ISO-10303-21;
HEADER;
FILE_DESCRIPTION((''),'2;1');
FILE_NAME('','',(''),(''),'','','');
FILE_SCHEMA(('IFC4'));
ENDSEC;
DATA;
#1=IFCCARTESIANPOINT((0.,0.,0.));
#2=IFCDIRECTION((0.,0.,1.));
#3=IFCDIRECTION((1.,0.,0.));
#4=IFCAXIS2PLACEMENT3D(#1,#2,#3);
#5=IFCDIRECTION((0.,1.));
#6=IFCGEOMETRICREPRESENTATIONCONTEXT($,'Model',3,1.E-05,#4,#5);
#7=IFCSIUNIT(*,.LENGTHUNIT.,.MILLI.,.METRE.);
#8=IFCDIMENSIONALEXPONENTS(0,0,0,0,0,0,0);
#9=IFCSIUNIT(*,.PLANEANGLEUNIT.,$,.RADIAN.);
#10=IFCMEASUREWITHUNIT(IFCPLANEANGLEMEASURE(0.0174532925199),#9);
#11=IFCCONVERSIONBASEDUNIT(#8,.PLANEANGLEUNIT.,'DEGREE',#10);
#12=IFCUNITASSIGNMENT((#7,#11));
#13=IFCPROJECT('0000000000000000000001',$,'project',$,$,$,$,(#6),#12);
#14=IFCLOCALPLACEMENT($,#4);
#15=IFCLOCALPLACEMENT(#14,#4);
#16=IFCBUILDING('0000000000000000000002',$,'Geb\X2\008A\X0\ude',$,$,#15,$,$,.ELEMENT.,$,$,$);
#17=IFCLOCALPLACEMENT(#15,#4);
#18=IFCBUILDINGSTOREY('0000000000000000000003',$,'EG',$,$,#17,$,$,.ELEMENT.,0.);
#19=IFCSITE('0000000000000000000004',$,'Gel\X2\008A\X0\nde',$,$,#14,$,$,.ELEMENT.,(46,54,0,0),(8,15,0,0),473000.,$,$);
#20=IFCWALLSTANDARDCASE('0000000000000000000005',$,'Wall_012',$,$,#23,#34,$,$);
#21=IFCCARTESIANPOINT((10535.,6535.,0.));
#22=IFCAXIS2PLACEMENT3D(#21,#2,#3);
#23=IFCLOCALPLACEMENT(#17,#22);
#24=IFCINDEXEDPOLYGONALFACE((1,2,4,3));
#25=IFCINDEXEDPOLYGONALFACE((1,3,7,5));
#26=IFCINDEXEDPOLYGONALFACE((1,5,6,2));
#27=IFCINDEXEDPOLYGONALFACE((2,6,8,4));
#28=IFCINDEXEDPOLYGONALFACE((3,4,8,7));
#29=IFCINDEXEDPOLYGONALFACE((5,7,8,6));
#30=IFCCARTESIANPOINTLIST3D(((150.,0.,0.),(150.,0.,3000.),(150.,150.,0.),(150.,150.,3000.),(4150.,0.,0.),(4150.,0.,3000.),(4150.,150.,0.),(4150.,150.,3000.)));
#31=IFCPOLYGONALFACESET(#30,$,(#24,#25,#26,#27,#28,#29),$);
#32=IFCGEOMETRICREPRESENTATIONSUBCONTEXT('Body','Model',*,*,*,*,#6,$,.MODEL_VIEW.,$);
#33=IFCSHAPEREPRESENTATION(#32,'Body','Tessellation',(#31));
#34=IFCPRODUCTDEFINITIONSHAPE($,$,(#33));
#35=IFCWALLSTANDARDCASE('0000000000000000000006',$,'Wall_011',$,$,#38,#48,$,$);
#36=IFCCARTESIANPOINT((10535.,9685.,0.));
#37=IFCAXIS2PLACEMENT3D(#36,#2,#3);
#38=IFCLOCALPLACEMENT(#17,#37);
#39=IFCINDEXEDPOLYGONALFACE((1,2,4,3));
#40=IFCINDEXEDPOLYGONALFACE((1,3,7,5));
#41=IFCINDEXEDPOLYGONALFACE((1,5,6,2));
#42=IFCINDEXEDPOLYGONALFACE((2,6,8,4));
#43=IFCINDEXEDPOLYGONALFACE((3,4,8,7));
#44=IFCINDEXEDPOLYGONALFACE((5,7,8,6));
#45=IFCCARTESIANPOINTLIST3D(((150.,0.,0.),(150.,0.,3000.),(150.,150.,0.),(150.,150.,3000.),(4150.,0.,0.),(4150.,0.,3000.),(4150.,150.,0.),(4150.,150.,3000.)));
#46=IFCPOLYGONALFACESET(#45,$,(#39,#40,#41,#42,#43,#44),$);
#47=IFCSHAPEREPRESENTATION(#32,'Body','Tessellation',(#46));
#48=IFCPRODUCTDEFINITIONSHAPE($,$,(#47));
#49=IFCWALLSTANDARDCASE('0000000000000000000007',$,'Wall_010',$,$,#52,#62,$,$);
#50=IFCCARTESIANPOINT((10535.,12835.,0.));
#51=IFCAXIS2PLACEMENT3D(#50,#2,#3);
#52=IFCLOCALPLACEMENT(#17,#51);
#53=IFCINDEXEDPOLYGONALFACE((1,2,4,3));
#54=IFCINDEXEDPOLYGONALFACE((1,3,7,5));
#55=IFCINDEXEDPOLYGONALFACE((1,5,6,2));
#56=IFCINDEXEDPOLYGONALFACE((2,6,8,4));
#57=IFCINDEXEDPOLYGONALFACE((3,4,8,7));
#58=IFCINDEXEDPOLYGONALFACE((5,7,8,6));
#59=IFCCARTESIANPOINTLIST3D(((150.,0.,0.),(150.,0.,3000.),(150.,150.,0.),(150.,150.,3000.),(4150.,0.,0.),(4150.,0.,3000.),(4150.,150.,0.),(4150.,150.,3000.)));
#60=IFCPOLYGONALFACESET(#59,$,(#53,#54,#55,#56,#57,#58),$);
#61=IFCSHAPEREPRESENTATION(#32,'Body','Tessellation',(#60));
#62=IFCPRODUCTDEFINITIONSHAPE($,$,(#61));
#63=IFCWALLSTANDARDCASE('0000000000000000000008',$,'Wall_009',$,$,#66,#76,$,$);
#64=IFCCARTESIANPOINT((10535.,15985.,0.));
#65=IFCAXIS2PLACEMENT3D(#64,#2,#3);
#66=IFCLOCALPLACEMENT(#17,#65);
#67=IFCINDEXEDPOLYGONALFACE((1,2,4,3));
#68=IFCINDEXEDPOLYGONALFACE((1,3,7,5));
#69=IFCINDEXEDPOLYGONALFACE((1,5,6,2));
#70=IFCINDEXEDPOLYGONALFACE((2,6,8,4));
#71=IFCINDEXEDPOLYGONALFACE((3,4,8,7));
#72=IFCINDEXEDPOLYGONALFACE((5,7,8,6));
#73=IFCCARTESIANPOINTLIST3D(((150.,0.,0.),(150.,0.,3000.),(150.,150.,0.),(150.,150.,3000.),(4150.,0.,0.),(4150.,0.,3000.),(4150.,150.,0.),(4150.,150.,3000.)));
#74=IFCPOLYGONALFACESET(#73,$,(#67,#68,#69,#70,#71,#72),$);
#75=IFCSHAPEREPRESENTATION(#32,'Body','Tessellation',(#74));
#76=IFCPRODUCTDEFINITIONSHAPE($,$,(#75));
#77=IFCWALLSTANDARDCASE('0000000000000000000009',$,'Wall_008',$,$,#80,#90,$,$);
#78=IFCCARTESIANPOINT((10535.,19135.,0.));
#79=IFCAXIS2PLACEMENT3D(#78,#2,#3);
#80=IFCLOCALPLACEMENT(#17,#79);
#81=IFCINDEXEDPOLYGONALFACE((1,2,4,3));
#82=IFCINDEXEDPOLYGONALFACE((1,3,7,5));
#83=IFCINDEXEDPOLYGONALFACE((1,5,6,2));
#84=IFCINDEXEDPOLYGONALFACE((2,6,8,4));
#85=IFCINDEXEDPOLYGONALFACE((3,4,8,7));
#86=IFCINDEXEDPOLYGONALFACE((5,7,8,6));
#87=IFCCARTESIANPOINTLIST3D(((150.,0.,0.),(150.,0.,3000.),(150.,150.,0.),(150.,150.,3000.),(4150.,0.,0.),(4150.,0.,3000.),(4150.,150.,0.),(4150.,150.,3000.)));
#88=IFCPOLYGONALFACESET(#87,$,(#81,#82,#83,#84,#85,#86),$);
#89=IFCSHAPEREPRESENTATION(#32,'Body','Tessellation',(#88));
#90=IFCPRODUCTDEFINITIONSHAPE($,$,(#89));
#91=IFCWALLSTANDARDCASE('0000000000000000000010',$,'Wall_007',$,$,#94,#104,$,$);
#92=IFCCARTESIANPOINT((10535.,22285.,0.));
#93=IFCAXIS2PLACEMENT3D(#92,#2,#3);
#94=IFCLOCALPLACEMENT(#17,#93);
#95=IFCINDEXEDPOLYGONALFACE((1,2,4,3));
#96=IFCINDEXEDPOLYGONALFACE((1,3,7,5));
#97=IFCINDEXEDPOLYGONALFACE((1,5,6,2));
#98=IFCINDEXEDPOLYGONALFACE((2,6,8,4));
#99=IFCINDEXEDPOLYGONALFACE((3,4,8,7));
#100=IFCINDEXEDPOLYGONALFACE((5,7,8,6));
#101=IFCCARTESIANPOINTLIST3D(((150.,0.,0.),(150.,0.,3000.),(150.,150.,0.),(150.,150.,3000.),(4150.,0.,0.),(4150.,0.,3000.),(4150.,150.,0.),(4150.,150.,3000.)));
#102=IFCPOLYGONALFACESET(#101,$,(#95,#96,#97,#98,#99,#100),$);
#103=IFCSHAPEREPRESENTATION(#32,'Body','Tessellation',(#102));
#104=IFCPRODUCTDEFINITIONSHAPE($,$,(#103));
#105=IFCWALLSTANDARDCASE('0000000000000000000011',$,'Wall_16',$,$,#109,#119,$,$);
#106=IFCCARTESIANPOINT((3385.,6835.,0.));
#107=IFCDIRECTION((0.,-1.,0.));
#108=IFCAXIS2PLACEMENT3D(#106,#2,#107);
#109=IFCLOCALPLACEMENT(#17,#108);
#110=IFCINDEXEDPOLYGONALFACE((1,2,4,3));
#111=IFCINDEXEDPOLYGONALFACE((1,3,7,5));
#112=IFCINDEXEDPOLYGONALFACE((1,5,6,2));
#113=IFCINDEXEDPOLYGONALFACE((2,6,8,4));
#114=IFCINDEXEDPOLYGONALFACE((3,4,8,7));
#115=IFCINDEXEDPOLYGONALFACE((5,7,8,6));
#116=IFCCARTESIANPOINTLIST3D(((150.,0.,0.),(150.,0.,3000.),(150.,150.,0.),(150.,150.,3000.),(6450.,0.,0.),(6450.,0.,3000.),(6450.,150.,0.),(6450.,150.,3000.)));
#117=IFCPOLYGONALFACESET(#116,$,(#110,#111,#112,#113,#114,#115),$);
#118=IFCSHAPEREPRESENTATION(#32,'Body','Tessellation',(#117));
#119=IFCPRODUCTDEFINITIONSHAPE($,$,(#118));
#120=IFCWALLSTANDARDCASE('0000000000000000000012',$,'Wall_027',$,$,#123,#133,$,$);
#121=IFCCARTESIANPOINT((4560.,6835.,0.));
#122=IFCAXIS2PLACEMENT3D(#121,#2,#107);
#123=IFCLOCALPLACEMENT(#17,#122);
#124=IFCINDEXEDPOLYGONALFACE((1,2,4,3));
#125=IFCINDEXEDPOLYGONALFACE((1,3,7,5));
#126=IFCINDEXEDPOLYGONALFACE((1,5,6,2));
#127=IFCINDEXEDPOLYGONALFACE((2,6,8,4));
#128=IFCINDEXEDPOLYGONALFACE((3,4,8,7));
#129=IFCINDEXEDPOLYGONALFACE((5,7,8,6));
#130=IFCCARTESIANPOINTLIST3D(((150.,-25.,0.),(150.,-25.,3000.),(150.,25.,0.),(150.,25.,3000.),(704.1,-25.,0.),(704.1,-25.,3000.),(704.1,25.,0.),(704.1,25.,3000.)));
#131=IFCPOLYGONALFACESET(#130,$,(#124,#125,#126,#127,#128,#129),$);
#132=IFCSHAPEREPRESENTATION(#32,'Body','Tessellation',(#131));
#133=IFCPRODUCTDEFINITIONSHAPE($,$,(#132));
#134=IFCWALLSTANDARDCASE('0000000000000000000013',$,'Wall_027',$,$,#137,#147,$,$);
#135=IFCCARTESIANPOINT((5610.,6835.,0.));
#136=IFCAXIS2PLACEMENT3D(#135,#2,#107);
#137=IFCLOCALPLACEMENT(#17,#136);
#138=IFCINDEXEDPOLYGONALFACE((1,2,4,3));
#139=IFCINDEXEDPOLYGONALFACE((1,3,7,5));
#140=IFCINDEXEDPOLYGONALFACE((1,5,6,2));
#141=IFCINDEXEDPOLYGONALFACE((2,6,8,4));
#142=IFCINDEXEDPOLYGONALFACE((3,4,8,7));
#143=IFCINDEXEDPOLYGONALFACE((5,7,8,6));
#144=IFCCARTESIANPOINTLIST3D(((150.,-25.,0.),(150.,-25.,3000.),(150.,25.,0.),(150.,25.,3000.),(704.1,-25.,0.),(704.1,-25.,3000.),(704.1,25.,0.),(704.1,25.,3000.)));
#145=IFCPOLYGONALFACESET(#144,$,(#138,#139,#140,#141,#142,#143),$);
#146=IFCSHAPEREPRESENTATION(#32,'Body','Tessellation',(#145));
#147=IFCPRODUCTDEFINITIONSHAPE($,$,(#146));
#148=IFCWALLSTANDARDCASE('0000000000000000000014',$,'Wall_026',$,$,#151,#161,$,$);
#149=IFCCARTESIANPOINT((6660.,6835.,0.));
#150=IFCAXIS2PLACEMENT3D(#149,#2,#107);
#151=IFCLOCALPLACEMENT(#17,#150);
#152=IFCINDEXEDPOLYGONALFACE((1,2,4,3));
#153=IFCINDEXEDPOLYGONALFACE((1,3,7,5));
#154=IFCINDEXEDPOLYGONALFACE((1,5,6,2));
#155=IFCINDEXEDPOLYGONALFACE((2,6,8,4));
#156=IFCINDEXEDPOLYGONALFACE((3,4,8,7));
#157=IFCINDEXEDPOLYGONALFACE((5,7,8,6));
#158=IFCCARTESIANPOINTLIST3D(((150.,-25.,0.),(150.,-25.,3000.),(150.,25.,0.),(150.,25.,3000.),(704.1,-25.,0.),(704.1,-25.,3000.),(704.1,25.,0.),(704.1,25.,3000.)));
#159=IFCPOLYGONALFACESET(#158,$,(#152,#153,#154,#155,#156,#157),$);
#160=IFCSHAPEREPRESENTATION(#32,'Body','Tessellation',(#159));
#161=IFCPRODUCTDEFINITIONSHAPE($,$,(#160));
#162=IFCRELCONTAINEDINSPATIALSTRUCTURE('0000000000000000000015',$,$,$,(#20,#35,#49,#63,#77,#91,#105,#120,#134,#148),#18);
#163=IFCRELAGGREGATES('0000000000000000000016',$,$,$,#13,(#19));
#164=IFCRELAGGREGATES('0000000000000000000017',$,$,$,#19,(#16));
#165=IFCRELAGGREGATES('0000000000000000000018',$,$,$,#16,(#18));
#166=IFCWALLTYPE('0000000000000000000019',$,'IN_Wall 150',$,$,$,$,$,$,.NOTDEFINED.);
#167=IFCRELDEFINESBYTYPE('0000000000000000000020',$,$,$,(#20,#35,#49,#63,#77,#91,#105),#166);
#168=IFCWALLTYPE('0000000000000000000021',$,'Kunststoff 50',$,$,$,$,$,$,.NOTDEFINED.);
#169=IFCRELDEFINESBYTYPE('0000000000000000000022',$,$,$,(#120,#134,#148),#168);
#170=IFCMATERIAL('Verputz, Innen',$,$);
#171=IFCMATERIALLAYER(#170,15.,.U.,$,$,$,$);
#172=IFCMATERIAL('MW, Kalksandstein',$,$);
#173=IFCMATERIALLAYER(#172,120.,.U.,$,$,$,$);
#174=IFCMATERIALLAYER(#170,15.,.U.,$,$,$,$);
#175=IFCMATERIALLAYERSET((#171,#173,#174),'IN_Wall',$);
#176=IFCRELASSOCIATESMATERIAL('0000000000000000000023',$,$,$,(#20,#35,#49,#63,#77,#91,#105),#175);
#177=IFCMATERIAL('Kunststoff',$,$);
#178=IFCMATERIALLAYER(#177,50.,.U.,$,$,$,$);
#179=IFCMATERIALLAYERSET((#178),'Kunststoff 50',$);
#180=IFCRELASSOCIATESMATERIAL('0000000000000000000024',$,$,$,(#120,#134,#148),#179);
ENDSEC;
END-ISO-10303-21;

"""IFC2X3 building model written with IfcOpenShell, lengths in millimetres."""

from ifc_helpers import new_model, entity, si_unit, converted_unit, direction, frame, origin_with_axes, place, context, subcontext, project, spatial, polyline, outline, extrude, material, layer, layer_set, layer_usage, type_object, element, save


model = new_model("IFC2X3")

# Units and contexts
model_context = context("Model", 3, precision=1e-05, world=origin_with_axes(), true_north=direction((0.0, 1.0)))
body_context = subcontext(model_context, "Body", "Model", "MODEL_VIEW")
ifc_project = project(units=[si_unit("LENGTHUNIT", "METRE", prefix="MILLI"), converted_unit("PLANEANGLEUNIT", "DEGREE", entity("IfcPlaneAngleMeasure", 0.0174532925199), si_unit("PLANEANGLEUNIT", "RADIAN"), dimensions=[0, 0, 0, 0, 0, 0, 0])], contexts=[model_context])

# Site, building, storey
site_placement = place(None, origin_with_axes())
site = spatial("IfcSite", under=ifc_project, at=site_placement, Name="Gel\u008ande", CompositionType="ELEMENT", RefLatitude=(46, 54, 0, 0), RefLongitude=(8, 15, 0, 0), RefElevation=473000.0)
building_placement = place(site_placement, origin_with_axes())
building = spatial("IfcBuilding", under=site, at=building_placement, Name="Geb\u008aude", CompositionType="ELEMENT")
storey_placement = place(building_placement, origin_with_axes())
storey = spatial("IfcBuildingStorey", under=building, at=storey_placement, Name="EG", CompositionType="ELEMENT", Elevation=0.0)

# Shared definitions
ifc_material_1 = material(Name="Verputz, Innen")
ifc_layer_1 = layer(ifc_material_1, 15.0, ventilated="UNKNOWN")
ifc_material_2 = material(Name="MW, Kalksandstein")
ifc_layer_2 = layer(ifc_material_2, 120.0, ventilated="UNKNOWN")
ifc_layer_3 = layer(ifc_material_1, 15.0, ventilated="UNKNOWN")
ifc_layer_set_1 = layer_set([ifc_layer_1, ifc_layer_2, ifc_layer_3], Name="IN_Wall")
wall_type_1 = type_object("IfcWallType", Name="IN_Wall 150", PredefinedType="NOTDEFINED")

# Walls
ifc_layer_usage_1 = layer_usage(ifc_layer_set_1, "AXIS2", "POSITIVE", 0.0)
wall_1_placement = place(storey_placement, frame((10535.0, 6535.0, 0.0), z_axis=(0.0, 0.0, 1.0), x_axis=(1.0, 0.0, 0.0)))
element("IfcWallStandardCase", 1, at=wall_1_placement, inside=storey, type_object=wall_type_1, material=ifc_layer_usage_1, Name="Wall_012", context=body_context, shape_type="SweptSolid", body=[
    extrude(outline(polyline([(150.0, 0.0), (4150.0, 0.0), (4150.0, 150.0), (150.0, 150.0), (150.0, 0.0)])), origin_with_axes(), (0.0, 0.0, 1.0), 3000.0),
])
ifc_layer_usage_2 = layer_usage(ifc_layer_set_1, "AXIS2", "POSITIVE", 0.0)
wall_2_placement = place(storey_placement, frame((10535.0, 9685.0, 0.0), z_axis=(0.0, 0.0, 1.0), x_axis=(1.0, 0.0, 0.0)))
element("IfcWallStandardCase", 2, at=wall_2_placement, inside=storey, type_object=wall_type_1, material=ifc_layer_usage_2, Name="Wall_011", context=body_context, shape_type="SweptSolid", body=[
    extrude(outline(polyline([(150.0, 0.0), (4150.0, 0.0), (4150.0, 150.0), (150.0, 150.0), (150.0, 0.0)])), origin_with_axes(), (0.0, 0.0, 1.0), 3000.0),
])
ifc_layer_usage_3 = layer_usage(ifc_layer_set_1, "AXIS2", "POSITIVE", 0.0)
wall_3_placement = place(storey_placement, frame((10535.0, 12835.0, 0.0), z_axis=(0.0, 0.0, 1.0), x_axis=(1.0, 0.0, 0.0)))
element("IfcWallStandardCase", 3, at=wall_3_placement, inside=storey, type_object=wall_type_1, material=ifc_layer_usage_3, Name="Wall_010", context=body_context, shape_type="SweptSolid", body=[
    extrude(outline(polyline([(150.0, 0.0), (4150.0, 0.0), (4150.0, 150.0), (150.0, 150.0), (150.0, 0.0)])), origin_with_axes(), (0.0, 0.0, 1.0), 3000.0),
])
ifc_layer_usage_4 = layer_usage(ifc_layer_set_1, "AXIS2", "POSITIVE", 0.0)
wall_4_placement = place(storey_placement, frame((10535.0, 15985.0, 0.0), z_axis=(0.0, 0.0, 1.0), x_axis=(1.0, 0.0, 0.0)))
element("IfcWallStandardCase", 4, at=wall_4_placement, inside=storey, type_object=wall_type_1, material=ifc_layer_usage_4, Name="Wall_009", context=body_context, shape_type="SweptSolid", body=[
    extrude(outline(polyline([(150.0, 0.0), (4150.0, 0.0), (4150.0, 150.0), (150.0, 150.0), (150.0, 0.0)])), origin_with_axes(), (0.0, 0.0, 1.0), 3000.0),
])
ifc_layer_usage_5 = layer_usage(ifc_layer_set_1, "AXIS2", "POSITIVE", 0.0)
wall_5_placement = place(storey_placement, frame((10535.0, 19135.0, 0.0), z_axis=(0.0, 0.0, 1.0), x_axis=(1.0, 0.0, 0.0)))
element("IfcWallStandardCase", 5, at=wall_5_placement, inside=storey, type_object=wall_type_1, material=ifc_layer_usage_5, Name="Wall_008", context=body_context, shape_type="SweptSolid", body=[
    extrude(outline(polyline([(150.0, 0.0), (4150.0, 0.0), (4150.0, 150.0), (150.0, 150.0), (150.0, 0.0)])), origin_with_axes(), (0.0, 0.0, 1.0), 3000.0),
])
ifc_layer_usage_6 = layer_usage(ifc_layer_set_1, "AXIS2", "POSITIVE", 0.0)
wall_6_placement = place(storey_placement, frame((10535.0, 22285.0, 0.0), z_axis=(0.0, 0.0, 1.0), x_axis=(1.0, 0.0, 0.0)))
element("IfcWallStandardCase", 6, at=wall_6_placement, inside=storey, type_object=wall_type_1, material=ifc_layer_usage_6, Name="Wall_007", context=body_context, shape_type="SweptSolid", body=[
    extrude(outline(polyline([(150.0, 0.0), (4150.0, 0.0), (4150.0, 150.0), (150.0, 150.0), (150.0, 0.0)])), origin_with_axes(), (0.0, 0.0, 1.0), 3000.0),
])

# Walls
ifc_layer_usage_7 = layer_usage(ifc_layer_set_1, "AXIS2", "POSITIVE", 0.0)
wall_7_placement = place(storey_placement, frame((3385.0, 6835.0, 0.0), z_axis=(0.0, 0.0, 1.0), x_axis=(0.0, -1.0, 0.0)))
element("IfcWallStandardCase", 7, at=wall_7_placement, inside=storey, type_object=wall_type_1, material=ifc_layer_usage_7, Name="Wall_16", context=body_context, shape_type="SweptSolid", body=[
    extrude(outline(polyline([(150.0, 0.0), (6450.0, 0.0), (6450.0, 150.0), (150.0, 150.0), (150.0, 0.0)])), origin_with_axes(), (0.0, 0.0, 1.0), 3000.0),
])
ifc_material_3 = material(Name="Kunststoff")
ifc_layer_4 = layer(ifc_material_3, 50.0, ventilated="UNKNOWN")
ifc_layer_set_2 = layer_set([ifc_layer_4], Name="Kunststoff 50")
ifc_layer_usage_8 = layer_usage(ifc_layer_set_2, "AXIS2", "POSITIVE", -25.0)
wall_type_2 = type_object("IfcWallType", Name="Kunststoff 50", PredefinedType="NOTDEFINED")
wall_8_placement = place(storey_placement, frame((4560.0, 6835.0, 0.0), z_axis=(0.0, 0.0, 1.0), x_axis=(0.0, -1.0, 0.0)))
element("IfcWallStandardCase", 8, at=wall_8_placement, inside=storey, type_object=wall_type_2, material=ifc_layer_usage_8, Name="Wall_027", context=body_context, shape_type="SweptSolid", body=[
    extrude(outline(polyline([(150.0, -25.0), (704.1, -25.0), (704.1, 25.0), (150.0, 25.0), (150.0, -25.0)])), origin_with_axes(), (0.0, 0.0, 1.0), 3000.0),
])
ifc_layer_usage_9 = layer_usage(ifc_layer_set_2, "AXIS2", "POSITIVE", -25.0)
wall_9_placement = place(storey_placement, frame((5610.0, 6835.0, 0.0), z_axis=(0.0, 0.0, 1.0), x_axis=(0.0, -1.0, 0.0)))
element("IfcWallStandardCase", 9, at=wall_9_placement, inside=storey, type_object=wall_type_2, material=ifc_layer_usage_9, Name="Wall_027", context=body_context, shape_type="SweptSolid", body=[
    extrude(outline(polyline([(150.0, -25.0), (704.1, -25.0), (704.1, 25.0), (150.0, 25.0), (150.0, -25.0)])), origin_with_axes(), (0.0, 0.0, 1.0), 3000.0),
])
ifc_layer_usage_10 = layer_usage(ifc_layer_set_2, "AXIS2", "POSITIVE", -25.0)
wall_10_placement = place(storey_placement, frame((6660.0, 6835.0, 0.0), z_axis=(0.0, 0.0, 1.0), x_axis=(0.0, -1.0, 0.0)))
element("IfcWallStandardCase", 10, at=wall_10_placement, inside=storey, type_object=wall_type_2, material=ifc_layer_usage_10, Name="Wall_026", context=body_context, shape_type="SweptSolid", body=[
    extrude(outline(polyline([(150.0, -25.0), (704.1, -25.0), (704.1, 25.0), (150.0, 25.0), (150.0, -25.0)])), origin_with_axes(), (0.0, 0.0, 1.0), 3000.0),
])

save(model, "model.ifc")
